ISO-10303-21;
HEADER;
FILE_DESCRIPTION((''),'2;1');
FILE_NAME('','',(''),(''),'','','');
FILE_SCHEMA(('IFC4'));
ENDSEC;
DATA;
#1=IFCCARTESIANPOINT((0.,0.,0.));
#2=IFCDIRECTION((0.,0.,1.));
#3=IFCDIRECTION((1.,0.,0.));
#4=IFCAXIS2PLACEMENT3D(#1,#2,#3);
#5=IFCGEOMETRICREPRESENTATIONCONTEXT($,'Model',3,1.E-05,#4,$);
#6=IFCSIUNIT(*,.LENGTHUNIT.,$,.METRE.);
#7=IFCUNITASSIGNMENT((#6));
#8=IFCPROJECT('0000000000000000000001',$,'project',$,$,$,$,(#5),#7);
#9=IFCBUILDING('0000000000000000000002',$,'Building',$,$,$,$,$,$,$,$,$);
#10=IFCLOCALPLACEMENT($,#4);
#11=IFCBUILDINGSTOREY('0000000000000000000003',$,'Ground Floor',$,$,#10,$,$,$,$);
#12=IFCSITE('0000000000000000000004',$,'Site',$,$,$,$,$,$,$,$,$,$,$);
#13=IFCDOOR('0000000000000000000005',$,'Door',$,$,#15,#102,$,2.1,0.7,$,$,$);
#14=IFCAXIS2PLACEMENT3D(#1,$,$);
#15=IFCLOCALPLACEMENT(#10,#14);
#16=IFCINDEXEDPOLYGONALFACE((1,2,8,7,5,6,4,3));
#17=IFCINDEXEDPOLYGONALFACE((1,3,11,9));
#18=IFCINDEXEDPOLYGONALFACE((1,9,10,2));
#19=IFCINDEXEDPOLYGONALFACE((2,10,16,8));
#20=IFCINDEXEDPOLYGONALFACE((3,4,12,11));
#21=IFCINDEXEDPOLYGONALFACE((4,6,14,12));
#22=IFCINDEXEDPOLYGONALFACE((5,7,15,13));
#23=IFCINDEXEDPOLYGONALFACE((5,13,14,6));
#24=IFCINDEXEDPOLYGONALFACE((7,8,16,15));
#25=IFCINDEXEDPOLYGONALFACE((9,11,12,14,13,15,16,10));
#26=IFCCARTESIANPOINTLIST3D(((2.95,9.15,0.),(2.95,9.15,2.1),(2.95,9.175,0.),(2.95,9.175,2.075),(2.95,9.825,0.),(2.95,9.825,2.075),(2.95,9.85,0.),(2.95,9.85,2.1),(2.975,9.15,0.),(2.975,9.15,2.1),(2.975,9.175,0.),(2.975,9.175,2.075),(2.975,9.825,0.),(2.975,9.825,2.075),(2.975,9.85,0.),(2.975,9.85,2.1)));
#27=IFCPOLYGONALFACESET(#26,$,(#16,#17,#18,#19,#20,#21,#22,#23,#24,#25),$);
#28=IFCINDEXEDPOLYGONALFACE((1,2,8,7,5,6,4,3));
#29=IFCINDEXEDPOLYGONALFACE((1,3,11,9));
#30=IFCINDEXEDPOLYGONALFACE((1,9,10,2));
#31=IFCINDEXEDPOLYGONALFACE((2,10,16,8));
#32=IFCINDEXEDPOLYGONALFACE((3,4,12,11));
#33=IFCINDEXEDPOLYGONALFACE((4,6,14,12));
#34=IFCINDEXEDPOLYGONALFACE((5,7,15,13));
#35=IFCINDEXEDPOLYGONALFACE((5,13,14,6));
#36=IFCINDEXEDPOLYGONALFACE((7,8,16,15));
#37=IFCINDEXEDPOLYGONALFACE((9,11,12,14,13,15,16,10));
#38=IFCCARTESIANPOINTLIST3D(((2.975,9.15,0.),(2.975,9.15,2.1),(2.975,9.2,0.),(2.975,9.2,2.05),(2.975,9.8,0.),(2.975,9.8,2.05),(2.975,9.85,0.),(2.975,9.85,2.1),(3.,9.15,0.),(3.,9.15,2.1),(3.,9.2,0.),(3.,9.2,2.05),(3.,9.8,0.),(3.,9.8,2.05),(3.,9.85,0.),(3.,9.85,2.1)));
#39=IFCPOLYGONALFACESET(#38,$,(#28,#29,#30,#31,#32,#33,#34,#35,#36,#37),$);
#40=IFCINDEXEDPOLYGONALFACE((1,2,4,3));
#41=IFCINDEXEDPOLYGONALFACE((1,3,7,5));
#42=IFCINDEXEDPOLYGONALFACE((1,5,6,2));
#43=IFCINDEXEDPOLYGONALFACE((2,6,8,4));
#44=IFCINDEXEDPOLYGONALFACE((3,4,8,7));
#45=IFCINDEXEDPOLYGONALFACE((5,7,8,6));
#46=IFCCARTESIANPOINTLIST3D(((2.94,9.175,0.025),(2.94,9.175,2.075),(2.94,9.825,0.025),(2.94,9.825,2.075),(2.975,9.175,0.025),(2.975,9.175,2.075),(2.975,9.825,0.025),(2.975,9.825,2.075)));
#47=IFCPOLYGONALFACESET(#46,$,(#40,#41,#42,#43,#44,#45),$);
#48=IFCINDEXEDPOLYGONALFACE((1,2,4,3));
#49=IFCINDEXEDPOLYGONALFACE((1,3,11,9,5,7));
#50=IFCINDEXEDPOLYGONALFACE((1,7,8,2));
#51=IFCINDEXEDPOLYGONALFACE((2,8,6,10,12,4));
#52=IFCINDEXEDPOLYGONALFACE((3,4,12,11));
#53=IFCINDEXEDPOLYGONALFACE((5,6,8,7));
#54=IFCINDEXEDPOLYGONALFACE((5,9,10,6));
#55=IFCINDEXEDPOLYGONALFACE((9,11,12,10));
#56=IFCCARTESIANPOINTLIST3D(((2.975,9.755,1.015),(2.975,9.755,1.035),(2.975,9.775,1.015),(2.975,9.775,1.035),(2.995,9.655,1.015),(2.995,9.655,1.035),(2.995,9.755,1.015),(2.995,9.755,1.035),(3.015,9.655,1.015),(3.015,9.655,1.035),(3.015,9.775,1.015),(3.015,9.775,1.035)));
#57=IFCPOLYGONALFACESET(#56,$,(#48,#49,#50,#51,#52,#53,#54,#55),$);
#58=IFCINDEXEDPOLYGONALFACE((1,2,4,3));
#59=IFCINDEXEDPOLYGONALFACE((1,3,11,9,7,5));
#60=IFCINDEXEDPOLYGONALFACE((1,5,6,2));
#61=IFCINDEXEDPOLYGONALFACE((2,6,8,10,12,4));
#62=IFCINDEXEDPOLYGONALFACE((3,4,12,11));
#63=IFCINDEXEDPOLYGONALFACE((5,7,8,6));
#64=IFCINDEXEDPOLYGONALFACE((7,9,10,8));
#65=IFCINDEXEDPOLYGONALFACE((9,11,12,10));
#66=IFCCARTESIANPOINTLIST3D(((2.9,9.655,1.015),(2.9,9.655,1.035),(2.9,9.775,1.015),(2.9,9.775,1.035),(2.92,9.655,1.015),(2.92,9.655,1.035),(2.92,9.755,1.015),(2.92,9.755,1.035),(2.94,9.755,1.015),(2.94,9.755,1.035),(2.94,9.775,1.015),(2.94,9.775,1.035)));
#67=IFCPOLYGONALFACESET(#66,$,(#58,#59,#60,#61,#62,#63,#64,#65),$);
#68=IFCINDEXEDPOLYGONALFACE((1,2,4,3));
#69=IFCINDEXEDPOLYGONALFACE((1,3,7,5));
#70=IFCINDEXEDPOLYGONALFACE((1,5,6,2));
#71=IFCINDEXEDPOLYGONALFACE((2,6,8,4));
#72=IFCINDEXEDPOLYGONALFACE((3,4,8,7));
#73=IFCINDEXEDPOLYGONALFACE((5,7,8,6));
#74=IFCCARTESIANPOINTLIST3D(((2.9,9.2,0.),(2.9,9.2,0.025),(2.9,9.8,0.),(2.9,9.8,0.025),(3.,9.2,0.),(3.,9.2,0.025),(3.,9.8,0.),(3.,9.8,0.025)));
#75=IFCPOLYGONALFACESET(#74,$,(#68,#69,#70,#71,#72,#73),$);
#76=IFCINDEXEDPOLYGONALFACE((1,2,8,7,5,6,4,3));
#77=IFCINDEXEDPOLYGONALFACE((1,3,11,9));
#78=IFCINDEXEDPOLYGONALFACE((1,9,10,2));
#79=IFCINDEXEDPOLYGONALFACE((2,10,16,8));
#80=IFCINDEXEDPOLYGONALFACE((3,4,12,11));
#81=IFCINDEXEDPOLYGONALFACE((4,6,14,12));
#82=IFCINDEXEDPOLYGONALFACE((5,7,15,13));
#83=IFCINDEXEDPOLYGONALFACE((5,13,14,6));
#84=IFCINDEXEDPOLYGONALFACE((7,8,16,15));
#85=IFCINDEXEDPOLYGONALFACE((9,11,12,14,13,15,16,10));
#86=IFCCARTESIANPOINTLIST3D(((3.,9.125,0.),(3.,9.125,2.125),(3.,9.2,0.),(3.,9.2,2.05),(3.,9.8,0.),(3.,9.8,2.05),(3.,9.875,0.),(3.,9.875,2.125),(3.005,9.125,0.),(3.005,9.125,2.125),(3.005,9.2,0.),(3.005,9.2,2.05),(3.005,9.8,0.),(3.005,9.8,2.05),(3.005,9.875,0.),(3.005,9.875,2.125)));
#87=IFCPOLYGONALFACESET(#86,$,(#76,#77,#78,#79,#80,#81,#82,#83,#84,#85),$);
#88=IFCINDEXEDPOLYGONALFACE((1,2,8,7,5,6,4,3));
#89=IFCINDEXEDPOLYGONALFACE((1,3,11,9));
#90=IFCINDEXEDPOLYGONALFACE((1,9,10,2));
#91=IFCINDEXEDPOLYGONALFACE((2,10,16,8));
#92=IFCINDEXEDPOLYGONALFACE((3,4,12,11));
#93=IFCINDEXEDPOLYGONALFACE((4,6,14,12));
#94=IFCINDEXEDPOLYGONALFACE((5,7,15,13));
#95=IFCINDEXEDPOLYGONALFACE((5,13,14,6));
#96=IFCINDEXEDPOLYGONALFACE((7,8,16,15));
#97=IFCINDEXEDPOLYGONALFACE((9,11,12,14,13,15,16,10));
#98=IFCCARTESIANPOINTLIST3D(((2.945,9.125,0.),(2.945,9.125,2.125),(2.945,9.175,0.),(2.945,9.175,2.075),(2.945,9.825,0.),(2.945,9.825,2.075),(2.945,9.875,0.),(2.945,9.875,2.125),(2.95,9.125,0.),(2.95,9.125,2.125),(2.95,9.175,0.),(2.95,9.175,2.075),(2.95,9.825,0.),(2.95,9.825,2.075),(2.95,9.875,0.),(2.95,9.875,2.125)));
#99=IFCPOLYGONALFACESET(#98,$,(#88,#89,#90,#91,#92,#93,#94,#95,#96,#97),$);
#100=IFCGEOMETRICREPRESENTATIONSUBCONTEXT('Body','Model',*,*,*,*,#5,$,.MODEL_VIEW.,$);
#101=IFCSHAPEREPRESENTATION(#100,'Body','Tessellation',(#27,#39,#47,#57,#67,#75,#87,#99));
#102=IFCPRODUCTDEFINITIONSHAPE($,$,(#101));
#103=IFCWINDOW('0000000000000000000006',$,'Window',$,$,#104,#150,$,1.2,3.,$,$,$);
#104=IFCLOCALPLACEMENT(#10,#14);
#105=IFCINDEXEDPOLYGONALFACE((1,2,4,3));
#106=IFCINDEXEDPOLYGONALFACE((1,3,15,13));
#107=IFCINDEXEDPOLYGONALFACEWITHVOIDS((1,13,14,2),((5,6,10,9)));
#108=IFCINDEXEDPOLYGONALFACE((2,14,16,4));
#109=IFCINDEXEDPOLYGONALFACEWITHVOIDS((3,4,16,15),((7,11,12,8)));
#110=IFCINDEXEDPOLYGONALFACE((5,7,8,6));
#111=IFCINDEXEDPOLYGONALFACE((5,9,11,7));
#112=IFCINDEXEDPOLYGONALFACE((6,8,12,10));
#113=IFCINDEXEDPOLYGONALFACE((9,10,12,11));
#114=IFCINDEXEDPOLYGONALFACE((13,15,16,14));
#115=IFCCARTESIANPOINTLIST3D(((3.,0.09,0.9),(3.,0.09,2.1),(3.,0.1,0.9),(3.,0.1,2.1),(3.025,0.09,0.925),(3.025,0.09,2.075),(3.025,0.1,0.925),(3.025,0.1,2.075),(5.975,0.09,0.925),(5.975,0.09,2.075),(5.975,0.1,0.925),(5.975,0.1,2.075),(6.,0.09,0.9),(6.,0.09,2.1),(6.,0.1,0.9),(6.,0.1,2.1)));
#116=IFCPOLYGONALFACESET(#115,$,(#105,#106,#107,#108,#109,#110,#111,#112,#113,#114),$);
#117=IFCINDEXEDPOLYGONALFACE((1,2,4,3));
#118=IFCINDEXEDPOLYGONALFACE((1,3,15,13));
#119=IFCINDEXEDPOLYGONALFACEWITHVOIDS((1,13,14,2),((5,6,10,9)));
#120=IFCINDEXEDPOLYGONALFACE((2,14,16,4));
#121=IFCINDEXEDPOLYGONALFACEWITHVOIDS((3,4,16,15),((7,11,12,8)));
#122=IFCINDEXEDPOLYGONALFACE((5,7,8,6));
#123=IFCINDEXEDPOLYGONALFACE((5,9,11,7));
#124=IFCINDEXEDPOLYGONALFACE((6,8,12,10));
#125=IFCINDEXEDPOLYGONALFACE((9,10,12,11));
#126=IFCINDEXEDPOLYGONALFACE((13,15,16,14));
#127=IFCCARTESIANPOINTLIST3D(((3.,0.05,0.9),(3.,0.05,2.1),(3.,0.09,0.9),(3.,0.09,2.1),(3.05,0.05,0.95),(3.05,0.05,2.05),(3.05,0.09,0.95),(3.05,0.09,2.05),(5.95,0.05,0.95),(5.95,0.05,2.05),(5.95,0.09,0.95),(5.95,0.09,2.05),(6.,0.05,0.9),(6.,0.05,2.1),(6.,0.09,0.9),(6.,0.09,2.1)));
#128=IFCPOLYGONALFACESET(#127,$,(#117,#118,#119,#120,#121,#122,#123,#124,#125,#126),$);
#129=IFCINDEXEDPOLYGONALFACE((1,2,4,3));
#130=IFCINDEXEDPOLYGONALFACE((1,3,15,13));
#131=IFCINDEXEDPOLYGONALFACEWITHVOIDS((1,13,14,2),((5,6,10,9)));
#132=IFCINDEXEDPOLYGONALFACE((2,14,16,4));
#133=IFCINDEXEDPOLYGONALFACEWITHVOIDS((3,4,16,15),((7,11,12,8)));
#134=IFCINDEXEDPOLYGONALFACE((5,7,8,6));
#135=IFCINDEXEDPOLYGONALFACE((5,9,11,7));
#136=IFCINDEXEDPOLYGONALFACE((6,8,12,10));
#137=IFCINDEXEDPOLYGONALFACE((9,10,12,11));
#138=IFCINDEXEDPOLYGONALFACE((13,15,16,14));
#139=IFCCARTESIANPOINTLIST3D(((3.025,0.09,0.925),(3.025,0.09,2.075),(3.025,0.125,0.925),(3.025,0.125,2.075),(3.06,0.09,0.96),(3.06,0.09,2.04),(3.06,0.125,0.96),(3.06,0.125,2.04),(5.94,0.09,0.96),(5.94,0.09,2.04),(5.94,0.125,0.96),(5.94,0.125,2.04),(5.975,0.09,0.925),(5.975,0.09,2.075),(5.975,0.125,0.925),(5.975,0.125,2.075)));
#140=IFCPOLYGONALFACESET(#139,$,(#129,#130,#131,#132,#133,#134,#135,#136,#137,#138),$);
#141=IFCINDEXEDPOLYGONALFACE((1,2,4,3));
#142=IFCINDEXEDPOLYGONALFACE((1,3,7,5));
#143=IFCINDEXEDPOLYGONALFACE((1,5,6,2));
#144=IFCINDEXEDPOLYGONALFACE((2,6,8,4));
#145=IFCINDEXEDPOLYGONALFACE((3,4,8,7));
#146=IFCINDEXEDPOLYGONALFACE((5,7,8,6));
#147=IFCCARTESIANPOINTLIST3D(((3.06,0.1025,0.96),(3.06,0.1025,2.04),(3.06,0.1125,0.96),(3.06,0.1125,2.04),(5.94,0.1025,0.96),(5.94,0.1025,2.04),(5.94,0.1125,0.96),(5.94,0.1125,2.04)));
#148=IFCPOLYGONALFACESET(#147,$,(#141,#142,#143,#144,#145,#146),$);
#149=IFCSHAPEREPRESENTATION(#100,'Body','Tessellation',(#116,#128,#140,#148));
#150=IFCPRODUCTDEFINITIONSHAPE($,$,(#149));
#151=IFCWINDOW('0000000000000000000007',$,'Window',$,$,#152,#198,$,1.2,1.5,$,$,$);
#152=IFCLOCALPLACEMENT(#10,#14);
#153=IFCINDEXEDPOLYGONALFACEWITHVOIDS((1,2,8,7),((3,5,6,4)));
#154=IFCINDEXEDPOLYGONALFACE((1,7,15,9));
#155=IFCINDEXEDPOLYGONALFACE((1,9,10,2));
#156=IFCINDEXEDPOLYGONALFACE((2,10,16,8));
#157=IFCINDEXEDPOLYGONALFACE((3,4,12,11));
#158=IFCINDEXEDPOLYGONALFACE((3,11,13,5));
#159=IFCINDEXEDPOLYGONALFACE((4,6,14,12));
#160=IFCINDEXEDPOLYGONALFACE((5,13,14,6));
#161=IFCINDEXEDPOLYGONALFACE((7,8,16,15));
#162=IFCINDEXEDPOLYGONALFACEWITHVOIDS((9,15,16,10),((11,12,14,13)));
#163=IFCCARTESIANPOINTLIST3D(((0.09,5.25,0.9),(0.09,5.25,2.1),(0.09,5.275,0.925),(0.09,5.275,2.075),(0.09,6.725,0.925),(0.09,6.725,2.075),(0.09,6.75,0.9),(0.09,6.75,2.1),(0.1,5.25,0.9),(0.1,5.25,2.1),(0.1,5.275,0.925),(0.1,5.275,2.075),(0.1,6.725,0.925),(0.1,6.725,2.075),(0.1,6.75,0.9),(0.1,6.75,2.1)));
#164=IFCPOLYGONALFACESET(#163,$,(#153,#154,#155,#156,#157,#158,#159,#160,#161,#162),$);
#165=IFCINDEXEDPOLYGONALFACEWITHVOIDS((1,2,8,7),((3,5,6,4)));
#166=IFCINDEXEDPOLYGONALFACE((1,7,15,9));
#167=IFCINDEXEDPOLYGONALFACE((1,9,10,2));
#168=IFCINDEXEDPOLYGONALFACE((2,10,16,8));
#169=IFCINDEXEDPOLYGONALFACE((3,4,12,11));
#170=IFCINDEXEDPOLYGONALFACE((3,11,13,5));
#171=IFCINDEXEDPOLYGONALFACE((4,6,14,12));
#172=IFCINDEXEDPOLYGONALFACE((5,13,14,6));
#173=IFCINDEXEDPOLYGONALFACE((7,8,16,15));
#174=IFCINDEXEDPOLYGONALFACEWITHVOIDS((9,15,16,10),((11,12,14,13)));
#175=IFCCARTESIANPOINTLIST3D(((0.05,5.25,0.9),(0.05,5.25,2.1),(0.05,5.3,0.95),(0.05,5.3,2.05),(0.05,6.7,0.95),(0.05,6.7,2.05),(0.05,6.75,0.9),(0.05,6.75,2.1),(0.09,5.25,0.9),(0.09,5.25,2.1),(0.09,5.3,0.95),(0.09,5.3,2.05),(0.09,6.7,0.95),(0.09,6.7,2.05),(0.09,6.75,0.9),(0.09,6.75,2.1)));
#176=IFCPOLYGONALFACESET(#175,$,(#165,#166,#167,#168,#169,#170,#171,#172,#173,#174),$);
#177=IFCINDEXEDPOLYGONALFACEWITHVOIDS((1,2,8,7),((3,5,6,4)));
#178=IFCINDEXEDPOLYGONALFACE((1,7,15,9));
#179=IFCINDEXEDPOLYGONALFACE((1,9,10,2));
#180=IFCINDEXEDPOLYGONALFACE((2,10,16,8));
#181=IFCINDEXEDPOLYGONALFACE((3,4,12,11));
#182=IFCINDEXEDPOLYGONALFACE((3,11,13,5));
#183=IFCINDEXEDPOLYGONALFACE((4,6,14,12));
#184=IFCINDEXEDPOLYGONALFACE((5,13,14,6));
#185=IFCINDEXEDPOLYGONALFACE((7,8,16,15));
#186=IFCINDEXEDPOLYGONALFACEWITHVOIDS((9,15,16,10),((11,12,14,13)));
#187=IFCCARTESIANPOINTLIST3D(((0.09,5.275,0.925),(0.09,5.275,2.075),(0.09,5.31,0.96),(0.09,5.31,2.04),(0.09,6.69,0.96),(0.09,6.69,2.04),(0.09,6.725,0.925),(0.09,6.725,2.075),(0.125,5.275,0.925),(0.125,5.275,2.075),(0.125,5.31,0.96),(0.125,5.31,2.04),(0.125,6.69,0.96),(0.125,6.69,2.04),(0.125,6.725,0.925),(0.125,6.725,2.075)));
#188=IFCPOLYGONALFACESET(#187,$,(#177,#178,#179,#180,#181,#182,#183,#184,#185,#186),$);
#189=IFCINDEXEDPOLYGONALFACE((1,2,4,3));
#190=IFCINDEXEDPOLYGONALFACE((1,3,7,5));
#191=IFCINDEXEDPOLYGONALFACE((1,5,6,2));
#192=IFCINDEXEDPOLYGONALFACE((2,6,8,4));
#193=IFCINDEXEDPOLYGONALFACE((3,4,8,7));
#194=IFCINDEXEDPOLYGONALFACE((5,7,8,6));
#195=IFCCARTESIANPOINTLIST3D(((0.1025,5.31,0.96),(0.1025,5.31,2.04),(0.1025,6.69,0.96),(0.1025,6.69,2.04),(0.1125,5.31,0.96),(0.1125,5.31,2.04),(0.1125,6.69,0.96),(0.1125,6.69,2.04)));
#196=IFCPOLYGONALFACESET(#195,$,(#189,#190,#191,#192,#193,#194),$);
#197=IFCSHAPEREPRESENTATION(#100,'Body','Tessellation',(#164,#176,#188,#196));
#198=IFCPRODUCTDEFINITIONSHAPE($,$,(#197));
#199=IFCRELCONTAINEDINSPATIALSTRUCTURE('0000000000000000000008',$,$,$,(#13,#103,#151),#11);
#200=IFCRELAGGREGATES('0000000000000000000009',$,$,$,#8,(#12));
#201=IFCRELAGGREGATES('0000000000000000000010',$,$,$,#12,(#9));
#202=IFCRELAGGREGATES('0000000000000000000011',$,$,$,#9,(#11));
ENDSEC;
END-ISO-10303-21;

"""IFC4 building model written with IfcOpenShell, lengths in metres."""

from ifc_helpers import new_model, si_unit, frame, origin_with_axes, place, context, subcontext, project, spatial, line, indexed_curve, outline, extrude, element, save


model = new_model("IFC4")

# Units and contexts
model_context = context("Model", 3, precision=1e-05, world=origin_with_axes())
body_context = subcontext(model_context, "Body", "Model", "MODEL_VIEW")
ifc_project = project(units=[si_unit("LENGTHUNIT", "METRE")], contexts=[model_context])

# Site, building, storey
site = spatial("IfcSite", under=ifc_project, Name="Site")
building = spatial("IfcBuilding", under=site, Name="Building")
storey_placement = place(None, origin_with_axes())
storey = spatial("IfcBuildingStorey", under=building, at=storey_placement, Name="Ground Floor")

# Door
door_1_placement = place(storey_placement, frame((3.0, 9.15, 0.0), z_axis=(0.0, 0.0, 1.0), x_axis=(0.0, 1.0, 0.0)))
element("IfcDoor", 1, at=door_1_placement, inside=storey, Name="Door", OverallHeight=2.1, OverallWidth=0.7, context=body_context, shape_type="SweptSolid", body=[
    extrude(outline(indexed_curve([(0.0, 0.0), (0.0, 2.1), (0.7, 2.1), (0.7, 0.0), (0.675, 0.0), (0.675, 2.075), (0.025, 2.075), (0.025, 0.0)], segments=[line(1, 2, 3, 4, 5, 6, 7, 8, 1)])), frame((0.0, 0.025, 0.0), z_axis=(0.0, -1.0, 0.0), x_axis=(1.0, 0.0, 0.0)), (0.0, 0.0, -1.0), 0.025),
    extrude(outline(indexed_curve([(0.0, 0.0), (0.0, 2.1), (0.7, 2.1), (0.7, 0.0), (0.65, 0.0), (0.65, 2.05), (0.05, 2.05), (0.05, 0.0)], segments=[line(1, 2, 3, 4, 5, 6, 7, 8, 1)])), frame((0.0, 0.0, 0.0), z_axis=(0.0, -1.0, 0.0), x_axis=(1.0, 0.0, 0.0)), (0.0, 0.0, -1.0), 0.025),
    extrude(outline(indexed_curve([(0.0, 0.0), (0.65, 0.0), (0.65, 0.035), (0.0, 0.035)], segments=[line(1, 2, 3, 4, 1)])), frame((0.025, 0.025, 0.025), z_axis=(0.0, 0.0, 1.0), x_axis=(1.0, 0.0, 0.0)), (0.0, 0.0, 1.0), 2.05),
    extrude(outline(indexed_curve([(0.0, 0.0), (0.0, -0.04), (-0.12, -0.04), (-0.12, -0.02), (-0.02, -0.02), (-0.02, 0.0)], segments=[line(1, 2, 3, 4, 5, 6, 1)])), frame((0.625, 0.025, 1.015), z_axis=(0.0, 0.0, 1.0), x_axis=(1.0, 0.0, 0.0)), (0.0, 0.0, 1.0), 0.02),
    extrude(outline(indexed_curve([(0.0, 0.0), (0.0, 0.04), (-0.12, 0.04), (-0.12, 0.02), (-0.02, 0.02), (-0.02, 0.0)], segments=[line(1, 2, 3, 4, 5, 6, 1)])), frame((0.625, 0.06, 1.015), z_axis=(0.0, 0.0, 1.0), x_axis=(1.0, 0.0, 0.0)), (0.0, 0.0, 1.0), 0.02),
    extrude(outline(indexed_curve([(0.0, 0.0), (0.6, 0.0), (0.6, 0.1), (0.0, 0.1)], segments=[line(1, 2, 3, 4, 1)])), frame((0.05, 0.0, 0.0), z_axis=(0.0, 0.0, 1.0), x_axis=(1.0, 0.0, 0.0)), (0.0, 0.0, 1.0), 0.025),
    extrude(outline(indexed_curve([(0.0, 0.0), (0.0, 2.125), (0.75, 2.125), (0.75, 0.0), (0.675, 0.0), (0.675, 2.05), (0.075, 2.05), (0.075, 0.0)], segments=[line(1, 2, 3, 4, 5, 6, 7, 8, 1)])), frame((-0.025, -0.005, 0.0), z_axis=(0.0, -1.0, 0.0), x_axis=(1.0, 0.0, 0.0)), (0.0, 0.0, -1.0), 0.005),
    extrude(outline(indexed_curve([(0.0, 0.0), (0.0, 2.125), (0.75, 2.125), (0.75, 0.0), (0.7, 0.0), (0.7, 2.075), (0.05, 2.075), (0.05, 0.0)], segments=[line(1, 2, 3, 4, 5, 6, 7, 8, 1)])), frame((-0.025, 0.05, 0.0), z_axis=(0.0, -1.0, 0.0), x_axis=(1.0, 0.0, 0.0)), (0.0, 0.0, -1.0), 0.005),
])

# Windows
window_1_placement = place(storey_placement, frame((3.0, 0.0, 0.9), z_axis=(0.0, 0.0, 1.0), x_axis=(1.0, 0.0, 0.0)))
element("IfcWindow", 2, at=window_1_placement, inside=storey, Name="Window", OverallHeight=1.2, OverallWidth=3.0, context=body_context, shape_type="SweptSolid", body=[
    extrude(outline(indexed_curve([(0.0, 0.0), (3.0, 0.0), (3.0, 1.2), (0.0, 1.2)], segments=[line(1, 2, 3, 4, 1)]), holes=[indexed_curve([(0.025, 0.025), (2.975, 0.025), (2.975, 1.175), (0.025, 1.175)], segments=[line(1, 2, 3, 4, 1)])]), frame((0.0, 0.09, 0.0), z_axis=(0.0, -1.0, 0.0), x_axis=(1.0, 0.0, 0.0)), (0.0, 0.0, -1.0), 0.01),
    extrude(outline(indexed_curve([(0.0, 0.0), (3.0, 0.0), (3.0, 1.2), (0.0, 1.2)], segments=[line(1, 2, 3, 4, 1)]), holes=[indexed_curve([(0.05, 0.05), (2.95, 0.05), (2.95, 1.15), (0.05, 1.15)], segments=[line(1, 2, 3, 4, 1)])]), frame((0.0, 0.05, 0.0), z_axis=(0.0, -1.0, 0.0), x_axis=(1.0, 0.0, 0.0)), (0.0, 0.0, -1.0), 0.04),
    extrude(outline(indexed_curve([(0.0, 0.0), (2.95, 0.0), (2.95, 1.15), (0.0, 1.15)], segments=[line(1, 2, 3, 4, 1)]), holes=[indexed_curve([(0.035, 0.035), (2.915, 0.035), (2.915, 1.115), (0.035, 1.115)], segments=[line(1, 2, 3, 4, 1)])]), frame((0.025, 0.09, 0.025), z_axis=(0.0, -1.0, 0.0), x_axis=(1.0, 0.0, 0.0)), (0.0, 0.0, -1.0), 0.035),
    extrude(outline(indexed_curve([(0.035, 0.035), (2.915, 0.035), (2.915, 1.115), (0.035, 1.115)], segments=[line(1, 2, 3, 4, 1)])), frame((0.025, 0.1025, 0.025), z_axis=(0.0, -1.0, 0.0), x_axis=(1.0, 0.0, 0.0)), (0.0, 0.0, -1.0), 0.01),
])
window_2_placement = place(storey_placement, frame((0.0, 6.75, 0.9), z_axis=(0.0, 0.0, 1.0), x_axis=(0.0, -1.0, 0.0)))
element("IfcWindow", 3, at=window_2_placement, inside=storey, Name="Window", OverallHeight=1.2, OverallWidth=1.5, context=body_context, shape_type="SweptSolid", body=[
    extrude(outline(indexed_curve([(0.0, 0.0), (1.5, 0.0), (1.5, 1.2), (0.0, 1.2)], segments=[line(1, 2, 3, 4, 1)]), holes=[indexed_curve([(0.025, 0.025), (1.475, 0.025), (1.475, 1.175), (0.025, 1.175)], segments=[line(1, 2, 3, 4, 1)])]), frame((0.0, 0.09, 0.0), z_axis=(0.0, -1.0, 0.0), x_axis=(1.0, 0.0, 0.0)), (0.0, 0.0, -1.0), 0.01),
    extrude(outline(indexed_curve([(0.0, 0.0), (1.5, 0.0), (1.5, 1.2), (0.0, 1.2)], segments=[line(1, 2, 3, 4, 1)]), holes=[indexed_curve([(0.05, 0.05), (1.45, 0.05), (1.45, 1.15), (0.05, 1.15)], segments=[line(1, 2, 3, 4, 1)])]), frame((0.0, 0.05, 0.0), z_axis=(0.0, -1.0, 0.0), x_axis=(1.0, 0.0, 0.0)), (0.0, 0.0, -1.0), 0.04),
    extrude(outline(indexed_curve([(0.0, 0.0), (1.45, 0.0), (1.45, 1.15), (0.0, 1.15)], segments=[line(1, 2, 3, 4, 1)]), holes=[indexed_curve([(0.035, 0.035), (1.415, 0.035), (1.415, 1.115), (0.035, 1.115)], segments=[line(1, 2, 3, 4, 1)])]), frame((0.025, 0.09, 0.025), z_axis=(0.0, -1.0, 0.0), x_axis=(1.0, 0.0, 0.0)), (0.0, 0.0, -1.0), 0.035),
    extrude(outline(indexed_curve([(0.035, 0.035), (1.415, 0.035), (1.415, 1.115), (0.035, 1.115)], segments=[line(1, 2, 3, 4, 1)])), frame((0.025, 0.1025, 0.025), z_axis=(0.0, -1.0, 0.0), x_axis=(1.0, 0.0, 0.0)), (0.0, 0.0, -1.0), 0.01),
])

save(model, "model.ifc")
